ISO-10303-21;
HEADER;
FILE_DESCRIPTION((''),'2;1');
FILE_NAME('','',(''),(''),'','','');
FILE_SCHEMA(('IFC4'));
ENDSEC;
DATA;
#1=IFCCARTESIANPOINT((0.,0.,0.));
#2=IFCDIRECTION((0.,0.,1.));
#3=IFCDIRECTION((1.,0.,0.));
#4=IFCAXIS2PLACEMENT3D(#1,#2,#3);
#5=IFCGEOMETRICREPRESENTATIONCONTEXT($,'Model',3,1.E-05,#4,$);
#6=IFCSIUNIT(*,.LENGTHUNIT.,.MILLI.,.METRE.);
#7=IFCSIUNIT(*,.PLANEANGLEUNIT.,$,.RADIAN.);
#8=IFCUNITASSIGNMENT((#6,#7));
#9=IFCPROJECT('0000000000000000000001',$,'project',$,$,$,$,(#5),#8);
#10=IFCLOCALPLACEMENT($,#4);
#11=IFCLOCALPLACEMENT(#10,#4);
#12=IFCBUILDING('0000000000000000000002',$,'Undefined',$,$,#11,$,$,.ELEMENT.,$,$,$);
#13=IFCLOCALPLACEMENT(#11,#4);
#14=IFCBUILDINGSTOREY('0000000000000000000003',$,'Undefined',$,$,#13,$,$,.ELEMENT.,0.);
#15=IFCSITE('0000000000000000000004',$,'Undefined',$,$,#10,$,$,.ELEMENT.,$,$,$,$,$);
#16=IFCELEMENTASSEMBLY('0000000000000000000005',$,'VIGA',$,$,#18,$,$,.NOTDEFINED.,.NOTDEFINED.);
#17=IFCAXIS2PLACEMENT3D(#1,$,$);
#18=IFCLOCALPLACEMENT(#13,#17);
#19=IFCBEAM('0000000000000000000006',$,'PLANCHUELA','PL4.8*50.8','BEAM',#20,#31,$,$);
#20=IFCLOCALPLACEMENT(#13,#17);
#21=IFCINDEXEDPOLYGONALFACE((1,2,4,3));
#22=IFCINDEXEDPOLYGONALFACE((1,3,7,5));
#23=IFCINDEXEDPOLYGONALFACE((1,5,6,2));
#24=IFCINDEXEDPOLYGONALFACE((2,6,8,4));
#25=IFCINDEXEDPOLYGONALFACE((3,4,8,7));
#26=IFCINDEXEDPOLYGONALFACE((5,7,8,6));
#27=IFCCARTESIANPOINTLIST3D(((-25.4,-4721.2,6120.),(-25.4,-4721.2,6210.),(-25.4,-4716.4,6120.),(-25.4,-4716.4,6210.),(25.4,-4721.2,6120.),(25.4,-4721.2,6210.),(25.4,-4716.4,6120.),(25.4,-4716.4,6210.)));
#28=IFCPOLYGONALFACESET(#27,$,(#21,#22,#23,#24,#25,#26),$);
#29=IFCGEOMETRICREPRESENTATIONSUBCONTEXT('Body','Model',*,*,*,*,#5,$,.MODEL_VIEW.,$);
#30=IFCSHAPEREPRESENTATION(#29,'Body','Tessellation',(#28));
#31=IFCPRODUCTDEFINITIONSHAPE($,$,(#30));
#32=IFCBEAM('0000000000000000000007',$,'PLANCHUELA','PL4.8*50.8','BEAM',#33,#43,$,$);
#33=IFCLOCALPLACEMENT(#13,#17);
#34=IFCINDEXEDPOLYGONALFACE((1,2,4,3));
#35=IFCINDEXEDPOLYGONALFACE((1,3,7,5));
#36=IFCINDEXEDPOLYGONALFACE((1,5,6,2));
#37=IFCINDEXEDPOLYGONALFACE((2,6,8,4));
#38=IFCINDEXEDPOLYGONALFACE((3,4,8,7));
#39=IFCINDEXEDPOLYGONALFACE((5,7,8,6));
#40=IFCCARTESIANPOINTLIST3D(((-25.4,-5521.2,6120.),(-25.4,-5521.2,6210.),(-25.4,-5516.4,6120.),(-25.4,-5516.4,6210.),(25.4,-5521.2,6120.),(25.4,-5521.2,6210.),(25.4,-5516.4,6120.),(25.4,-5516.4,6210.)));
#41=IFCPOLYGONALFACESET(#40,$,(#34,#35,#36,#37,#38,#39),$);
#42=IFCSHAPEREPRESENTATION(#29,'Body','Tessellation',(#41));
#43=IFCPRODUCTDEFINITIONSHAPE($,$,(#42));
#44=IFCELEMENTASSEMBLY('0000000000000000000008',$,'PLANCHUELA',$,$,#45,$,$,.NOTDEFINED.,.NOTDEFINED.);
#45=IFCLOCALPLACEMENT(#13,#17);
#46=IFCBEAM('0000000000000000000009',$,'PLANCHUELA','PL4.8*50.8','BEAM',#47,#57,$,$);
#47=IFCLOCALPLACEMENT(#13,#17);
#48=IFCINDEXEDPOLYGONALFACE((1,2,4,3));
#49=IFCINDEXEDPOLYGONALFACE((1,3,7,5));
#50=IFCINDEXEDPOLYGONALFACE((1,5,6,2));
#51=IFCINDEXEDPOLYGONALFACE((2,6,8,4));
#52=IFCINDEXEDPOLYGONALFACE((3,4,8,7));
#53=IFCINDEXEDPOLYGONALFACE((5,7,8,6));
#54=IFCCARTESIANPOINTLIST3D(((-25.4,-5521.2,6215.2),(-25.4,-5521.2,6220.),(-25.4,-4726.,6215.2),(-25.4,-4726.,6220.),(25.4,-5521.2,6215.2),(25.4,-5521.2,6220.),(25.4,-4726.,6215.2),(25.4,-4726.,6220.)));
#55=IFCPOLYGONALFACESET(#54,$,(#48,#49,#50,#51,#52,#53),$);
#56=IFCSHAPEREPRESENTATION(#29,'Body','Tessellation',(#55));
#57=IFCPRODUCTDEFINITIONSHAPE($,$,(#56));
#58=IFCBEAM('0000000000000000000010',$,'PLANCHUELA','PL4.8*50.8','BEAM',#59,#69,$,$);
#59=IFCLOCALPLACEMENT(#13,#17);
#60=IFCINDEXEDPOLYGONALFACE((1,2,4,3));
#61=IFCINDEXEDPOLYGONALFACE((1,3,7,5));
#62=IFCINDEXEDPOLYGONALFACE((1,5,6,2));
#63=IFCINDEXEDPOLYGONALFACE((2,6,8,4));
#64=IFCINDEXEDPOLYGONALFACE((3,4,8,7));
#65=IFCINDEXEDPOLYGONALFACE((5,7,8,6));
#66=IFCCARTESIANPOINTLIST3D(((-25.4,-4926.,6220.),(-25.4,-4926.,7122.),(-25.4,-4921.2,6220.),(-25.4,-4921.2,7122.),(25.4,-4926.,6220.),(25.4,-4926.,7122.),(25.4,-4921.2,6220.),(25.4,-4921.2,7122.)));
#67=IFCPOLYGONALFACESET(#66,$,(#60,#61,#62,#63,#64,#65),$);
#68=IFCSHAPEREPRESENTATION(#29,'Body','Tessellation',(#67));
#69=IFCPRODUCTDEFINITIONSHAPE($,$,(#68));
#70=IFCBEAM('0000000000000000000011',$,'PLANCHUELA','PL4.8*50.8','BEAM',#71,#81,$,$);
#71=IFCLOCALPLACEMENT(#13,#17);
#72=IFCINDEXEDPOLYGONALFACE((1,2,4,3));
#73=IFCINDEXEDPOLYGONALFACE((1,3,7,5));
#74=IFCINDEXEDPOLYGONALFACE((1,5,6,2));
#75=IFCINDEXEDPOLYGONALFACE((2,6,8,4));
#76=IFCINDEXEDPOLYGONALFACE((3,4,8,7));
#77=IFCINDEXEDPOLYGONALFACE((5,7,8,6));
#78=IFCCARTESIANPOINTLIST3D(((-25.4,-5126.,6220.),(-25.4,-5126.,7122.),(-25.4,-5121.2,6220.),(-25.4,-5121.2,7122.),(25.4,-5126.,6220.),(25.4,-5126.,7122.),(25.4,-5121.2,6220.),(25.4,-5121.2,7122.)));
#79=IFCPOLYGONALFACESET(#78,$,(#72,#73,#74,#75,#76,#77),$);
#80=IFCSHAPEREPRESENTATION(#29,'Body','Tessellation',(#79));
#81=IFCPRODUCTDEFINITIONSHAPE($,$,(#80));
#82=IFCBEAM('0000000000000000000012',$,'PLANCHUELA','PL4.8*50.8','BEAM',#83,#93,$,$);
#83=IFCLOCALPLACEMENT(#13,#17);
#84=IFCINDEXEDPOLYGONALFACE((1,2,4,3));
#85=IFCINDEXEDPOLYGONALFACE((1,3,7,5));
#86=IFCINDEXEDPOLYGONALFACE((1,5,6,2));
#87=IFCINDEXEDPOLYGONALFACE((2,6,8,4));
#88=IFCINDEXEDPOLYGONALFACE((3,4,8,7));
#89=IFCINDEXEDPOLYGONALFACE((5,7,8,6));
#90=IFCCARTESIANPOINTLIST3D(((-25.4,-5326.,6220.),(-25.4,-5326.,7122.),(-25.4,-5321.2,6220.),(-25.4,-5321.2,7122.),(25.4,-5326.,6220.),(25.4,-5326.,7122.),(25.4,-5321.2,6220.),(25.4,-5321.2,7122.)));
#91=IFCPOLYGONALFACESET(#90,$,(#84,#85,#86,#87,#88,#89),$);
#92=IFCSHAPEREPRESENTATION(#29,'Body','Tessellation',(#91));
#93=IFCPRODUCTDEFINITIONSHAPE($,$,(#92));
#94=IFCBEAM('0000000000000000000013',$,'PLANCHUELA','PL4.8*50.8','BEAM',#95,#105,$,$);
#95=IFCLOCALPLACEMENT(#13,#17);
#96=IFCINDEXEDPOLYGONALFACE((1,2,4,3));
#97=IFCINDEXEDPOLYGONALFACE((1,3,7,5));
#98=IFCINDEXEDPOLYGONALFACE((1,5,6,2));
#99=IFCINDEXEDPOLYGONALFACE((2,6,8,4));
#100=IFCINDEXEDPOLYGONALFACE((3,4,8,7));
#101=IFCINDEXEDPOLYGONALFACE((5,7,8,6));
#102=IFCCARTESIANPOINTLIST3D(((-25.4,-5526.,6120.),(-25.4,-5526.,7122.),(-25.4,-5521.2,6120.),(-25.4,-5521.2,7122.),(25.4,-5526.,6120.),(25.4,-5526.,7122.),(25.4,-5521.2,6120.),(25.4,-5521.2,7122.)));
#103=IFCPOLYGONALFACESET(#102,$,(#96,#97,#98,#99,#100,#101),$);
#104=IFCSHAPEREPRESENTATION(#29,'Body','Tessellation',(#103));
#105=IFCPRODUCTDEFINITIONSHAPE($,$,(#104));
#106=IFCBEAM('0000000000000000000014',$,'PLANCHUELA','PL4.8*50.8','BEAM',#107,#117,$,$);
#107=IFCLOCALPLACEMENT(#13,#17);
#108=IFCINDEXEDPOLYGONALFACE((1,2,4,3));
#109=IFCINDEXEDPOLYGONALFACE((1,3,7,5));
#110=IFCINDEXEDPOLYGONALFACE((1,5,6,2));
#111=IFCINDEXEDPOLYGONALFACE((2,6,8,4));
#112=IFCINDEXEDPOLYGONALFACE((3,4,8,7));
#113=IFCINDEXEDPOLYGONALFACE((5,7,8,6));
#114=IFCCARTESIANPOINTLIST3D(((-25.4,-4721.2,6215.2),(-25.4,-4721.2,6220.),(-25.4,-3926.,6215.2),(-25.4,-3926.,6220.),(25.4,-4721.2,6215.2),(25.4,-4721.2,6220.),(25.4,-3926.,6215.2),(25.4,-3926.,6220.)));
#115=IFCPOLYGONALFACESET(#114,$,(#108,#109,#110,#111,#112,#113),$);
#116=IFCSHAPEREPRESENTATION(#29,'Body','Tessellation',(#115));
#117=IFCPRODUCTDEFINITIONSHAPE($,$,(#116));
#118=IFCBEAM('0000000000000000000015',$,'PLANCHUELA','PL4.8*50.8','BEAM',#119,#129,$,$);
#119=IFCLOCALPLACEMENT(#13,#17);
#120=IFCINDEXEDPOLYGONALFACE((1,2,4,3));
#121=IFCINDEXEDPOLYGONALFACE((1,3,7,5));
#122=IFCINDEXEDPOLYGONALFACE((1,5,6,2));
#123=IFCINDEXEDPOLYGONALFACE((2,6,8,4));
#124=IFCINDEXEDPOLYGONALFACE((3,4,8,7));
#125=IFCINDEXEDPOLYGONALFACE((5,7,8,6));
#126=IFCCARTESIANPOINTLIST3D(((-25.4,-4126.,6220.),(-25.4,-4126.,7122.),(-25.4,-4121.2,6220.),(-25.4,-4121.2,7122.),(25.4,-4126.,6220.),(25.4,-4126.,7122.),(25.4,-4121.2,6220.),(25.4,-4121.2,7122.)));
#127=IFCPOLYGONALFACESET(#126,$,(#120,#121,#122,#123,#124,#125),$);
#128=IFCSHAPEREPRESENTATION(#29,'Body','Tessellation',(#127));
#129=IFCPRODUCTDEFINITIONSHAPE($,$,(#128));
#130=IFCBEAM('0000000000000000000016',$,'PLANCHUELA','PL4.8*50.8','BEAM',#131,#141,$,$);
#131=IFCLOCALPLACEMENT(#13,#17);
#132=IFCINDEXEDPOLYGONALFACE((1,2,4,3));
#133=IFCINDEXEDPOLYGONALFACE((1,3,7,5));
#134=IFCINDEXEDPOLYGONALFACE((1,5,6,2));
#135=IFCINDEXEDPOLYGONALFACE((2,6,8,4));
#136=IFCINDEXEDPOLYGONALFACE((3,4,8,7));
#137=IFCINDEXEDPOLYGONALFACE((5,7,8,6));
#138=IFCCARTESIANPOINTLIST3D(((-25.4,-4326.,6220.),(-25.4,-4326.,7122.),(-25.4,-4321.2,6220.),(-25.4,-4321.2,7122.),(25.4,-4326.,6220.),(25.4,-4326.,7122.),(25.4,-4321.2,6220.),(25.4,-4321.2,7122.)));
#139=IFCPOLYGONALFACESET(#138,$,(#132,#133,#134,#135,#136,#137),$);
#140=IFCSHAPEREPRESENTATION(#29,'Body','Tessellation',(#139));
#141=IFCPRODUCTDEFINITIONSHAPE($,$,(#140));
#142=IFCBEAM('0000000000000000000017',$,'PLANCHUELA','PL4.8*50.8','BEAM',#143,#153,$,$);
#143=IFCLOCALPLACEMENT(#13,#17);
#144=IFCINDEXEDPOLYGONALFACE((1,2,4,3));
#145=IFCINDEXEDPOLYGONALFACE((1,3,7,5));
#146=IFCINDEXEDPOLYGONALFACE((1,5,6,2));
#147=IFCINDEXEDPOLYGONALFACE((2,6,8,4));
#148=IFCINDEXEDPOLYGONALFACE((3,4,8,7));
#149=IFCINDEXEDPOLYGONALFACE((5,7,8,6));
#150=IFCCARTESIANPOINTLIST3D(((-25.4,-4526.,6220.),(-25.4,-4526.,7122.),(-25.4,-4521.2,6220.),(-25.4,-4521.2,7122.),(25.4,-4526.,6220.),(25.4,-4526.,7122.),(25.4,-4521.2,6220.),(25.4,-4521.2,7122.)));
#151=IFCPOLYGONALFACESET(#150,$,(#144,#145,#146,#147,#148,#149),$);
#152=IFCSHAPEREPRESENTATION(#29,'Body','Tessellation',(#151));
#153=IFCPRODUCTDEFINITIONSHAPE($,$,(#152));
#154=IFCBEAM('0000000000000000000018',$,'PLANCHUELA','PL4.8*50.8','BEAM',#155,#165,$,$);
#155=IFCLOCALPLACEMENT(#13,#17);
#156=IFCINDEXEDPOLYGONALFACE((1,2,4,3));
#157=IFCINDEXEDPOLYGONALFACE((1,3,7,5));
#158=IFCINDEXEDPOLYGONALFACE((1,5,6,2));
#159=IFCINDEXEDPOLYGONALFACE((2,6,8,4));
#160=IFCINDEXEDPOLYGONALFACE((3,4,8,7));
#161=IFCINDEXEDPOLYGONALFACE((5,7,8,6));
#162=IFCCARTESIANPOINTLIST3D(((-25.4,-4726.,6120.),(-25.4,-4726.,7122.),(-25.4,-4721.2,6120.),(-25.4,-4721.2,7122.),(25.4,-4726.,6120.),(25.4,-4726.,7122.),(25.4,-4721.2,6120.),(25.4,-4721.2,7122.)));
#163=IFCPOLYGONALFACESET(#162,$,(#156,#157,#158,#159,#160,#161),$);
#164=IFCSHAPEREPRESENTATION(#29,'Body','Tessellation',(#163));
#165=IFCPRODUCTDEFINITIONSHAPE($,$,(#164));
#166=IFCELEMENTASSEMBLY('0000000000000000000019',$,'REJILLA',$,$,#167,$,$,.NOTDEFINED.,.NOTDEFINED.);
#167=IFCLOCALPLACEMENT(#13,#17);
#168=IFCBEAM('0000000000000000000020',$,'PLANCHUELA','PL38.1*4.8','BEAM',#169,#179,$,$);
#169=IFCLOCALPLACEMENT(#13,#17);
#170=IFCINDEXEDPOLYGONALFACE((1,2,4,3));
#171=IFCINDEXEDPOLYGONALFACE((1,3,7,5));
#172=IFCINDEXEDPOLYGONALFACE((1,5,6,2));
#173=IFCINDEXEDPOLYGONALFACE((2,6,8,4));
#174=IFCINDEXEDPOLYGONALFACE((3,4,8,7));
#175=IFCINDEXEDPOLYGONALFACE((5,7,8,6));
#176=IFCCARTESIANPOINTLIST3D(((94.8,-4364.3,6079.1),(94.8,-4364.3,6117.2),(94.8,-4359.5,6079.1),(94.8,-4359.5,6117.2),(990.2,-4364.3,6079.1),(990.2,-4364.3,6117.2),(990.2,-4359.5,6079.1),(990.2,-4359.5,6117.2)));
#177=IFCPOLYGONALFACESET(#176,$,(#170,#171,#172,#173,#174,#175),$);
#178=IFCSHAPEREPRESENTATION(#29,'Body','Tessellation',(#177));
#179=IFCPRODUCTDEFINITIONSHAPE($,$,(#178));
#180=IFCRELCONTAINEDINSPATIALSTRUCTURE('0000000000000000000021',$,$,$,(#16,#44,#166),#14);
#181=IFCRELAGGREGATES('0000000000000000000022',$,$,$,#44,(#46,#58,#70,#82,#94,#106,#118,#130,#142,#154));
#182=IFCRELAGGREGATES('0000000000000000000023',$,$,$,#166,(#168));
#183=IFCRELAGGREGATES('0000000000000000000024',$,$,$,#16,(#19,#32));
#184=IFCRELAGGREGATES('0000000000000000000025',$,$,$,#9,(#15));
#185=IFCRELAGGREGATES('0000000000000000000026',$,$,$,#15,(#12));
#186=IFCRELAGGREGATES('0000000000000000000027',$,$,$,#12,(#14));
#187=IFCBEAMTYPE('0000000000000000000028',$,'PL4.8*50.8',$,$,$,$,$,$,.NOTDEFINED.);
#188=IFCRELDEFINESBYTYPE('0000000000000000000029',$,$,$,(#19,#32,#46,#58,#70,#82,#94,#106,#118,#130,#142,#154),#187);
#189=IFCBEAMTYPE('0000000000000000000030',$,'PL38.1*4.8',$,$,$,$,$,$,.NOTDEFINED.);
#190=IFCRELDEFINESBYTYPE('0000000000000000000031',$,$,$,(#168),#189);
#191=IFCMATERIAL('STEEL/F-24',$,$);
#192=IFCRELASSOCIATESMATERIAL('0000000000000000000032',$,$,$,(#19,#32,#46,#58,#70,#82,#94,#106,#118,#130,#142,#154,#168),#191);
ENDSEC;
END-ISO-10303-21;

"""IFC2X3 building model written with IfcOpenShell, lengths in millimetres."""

from ifc_helpers import new_model, si_unit, frame, origin_with_axes, origin_2d_with_axis, place, context, subcontext, project, spatial, rectangle, extrude, material, type_object, element, aggregate, save


model = new_model("IFC2X3")

# Units and contexts
model_context = context("Model", 3, precision=1e-05, world=origin_with_axes())
body_context = subcontext(model_context, "Body", "Model", "MODEL_VIEW")
ifc_project = project(units=[si_unit("LENGTHUNIT", "METRE", prefix="MILLI"), si_unit("PLANEANGLEUNIT", "RADIAN")], contexts=[model_context])

# Site, building, storey
site_placement = place(None, origin_with_axes())
site = spatial("IfcSite", under=ifc_project, at=site_placement, Name="Undefined", CompositionType="ELEMENT")
building_placement = place(site_placement, origin_with_axes())
building = spatial("IfcBuilding", under=site, at=building_placement, Name="Undefined", CompositionType="ELEMENT")
storey_placement = place(building_placement, origin_with_axes())
storey = spatial("IfcBuildingStorey", under=building, at=storey_placement, Name="Undefined", CompositionType="ELEMENT", Elevation=0.0)

# Element assemblies, beams
assembly_1_placement = place(storey_placement, origin_with_axes())
assembly_1 = element("IfcElementAssembly", 1, at=assembly_1_placement, inside=storey, Name="VIGA", AssemblyPlace="NOTDEFINED", PredefinedType="NOTDEFINED")
ifc_material_1 = material(Name="STEEL/F-24")
beam_type_1 = type_object("IfcBeamType", Name="PL4.8*50.8", PredefinedType="NOTDEFINED")
beam_1_placement = place(assembly_1_placement, frame((0.0, -4718.8, 6210.0), z_axis=(-1.0, 0.0, 0.0), x_axis=(0.0, 0.0, -1.0)))
beam_1 = element("IfcBeam", 2, at=beam_1_placement, type_object=beam_type_1, material=ifc_material_1, Name="PLANCHUELA", Description="PL4.8*50.8", ObjectType="BEAM", context=body_context, shape_type="SweptSolid", body=[
    extrude(rectangle(XDim=4.8, YDim=50.8, at=origin_2d_with_axis()), frame((90.0, 0.0, 0.0), z_axis=(-1.0, 0.0, 0.0), x_axis=(0.0, -1.0, 0.0)), (0.0, 0.0, 1.0), 90.0),
])
beam_2_placement = place(assembly_1_placement, frame((0.0, -5518.8, 6210.0), z_axis=(-1.0, 0.0, 0.0), x_axis=(0.0, 0.0, -1.0)))
beam_2 = element("IfcBeam", 3, at=beam_2_placement, type_object=beam_type_1, material=ifc_material_1, Name="PLANCHUELA", Description="PL4.8*50.8", ObjectType="BEAM", context=body_context, shape_type="SweptSolid", body=[
    extrude(rectangle(XDim=4.8, YDim=50.8, at=origin_2d_with_axis()), frame((90.0, 0.0, 0.0), z_axis=(-1.0, 0.0, 0.0), x_axis=(0.0, -1.0, 0.0)), (0.0, 0.0, 1.0), 90.0),
])
assembly_2_placement = place(storey_placement, origin_with_axes())
assembly_2 = element("IfcElementAssembly", 4, at=assembly_2_placement, inside=storey, Name="PLANCHUELA", AssemblyPlace="NOTDEFINED", PredefinedType="NOTDEFINED")
beam_3_placement = place(assembly_2_placement, frame((0.0, -5521.2, 6217.6), z_axis=(1.0, 0.0, 0.0), x_axis=(0.0, 1.0, 0.0)))
beam_3 = element("IfcBeam", 5, at=beam_3_placement, type_object=beam_type_1, material=ifc_material_1, Name="PLANCHUELA", Description="PL4.8*50.8", ObjectType="BEAM", context=body_context, shape_type="SweptSolid", body=[
    extrude(rectangle(XDim=4.8, YDim=50.8, at=origin_2d_with_axis()), frame((795.2, 0.0, 0.0), z_axis=(-1.0, 0.0, 0.0), x_axis=(0.0, -1.0, 0.0)), (0.0, 0.0, 1.0), 795.2),
])
beam_4_placement = place(assembly_2_placement, frame((0.0, -4923.6, 7122.0), z_axis=(1.0, 0.0, 0.0), x_axis=(0.0, 0.0, -1.0)))
beam_4 = element("IfcBeam", 6, at=beam_4_placement, type_object=beam_type_1, material=ifc_material_1, Name="PLANCHUELA", Description="PL4.8*50.8", ObjectType="BEAM", context=body_context, shape_type="SweptSolid", body=[
    extrude(rectangle(XDim=4.8, YDim=50.8, at=origin_2d_with_axis()), frame((902.0, 0.0, 0.0), z_axis=(-1.0, 0.0, 0.0), x_axis=(0.0, -1.0, 0.0)), (0.0, 0.0, 1.0), 902.0),
])
beam_5_placement = place(assembly_2_placement, frame((0.0, -5123.6, 7122.0), z_axis=(1.0, 0.0, 0.0), x_axis=(0.0, 0.0, -1.0)))
beam_5 = element("IfcBeam", 7, at=beam_5_placement, type_object=beam_type_1, material=ifc_material_1, Name="PLANCHUELA", Description="PL4.8*50.8", ObjectType="BEAM", context=body_context, shape_type="SweptSolid", body=[
    extrude(rectangle(XDim=4.8, YDim=50.8, at=origin_2d_with_axis()), frame((902.0, 0.0, 0.0), z_axis=(-1.0, 0.0, 0.0), x_axis=(0.0, -1.0, 0.0)), (0.0, 0.0, 1.0), 902.0),
])
beam_6_placement = place(assembly_2_placement, frame((0.0, -5323.6, 7122.0), z_axis=(1.0, 0.0, 0.0), x_axis=(0.0, 0.0, -1.0)))
beam_6 = element("IfcBeam", 8, at=beam_6_placement, type_object=beam_type_1, material=ifc_material_1, Name="PLANCHUELA", Description="PL4.8*50.8", ObjectType="BEAM", context=body_context, shape_type="SweptSolid", body=[
    extrude(rectangle(XDim=4.8, YDim=50.8, at=origin_2d_with_axis()), frame((902.0, 0.0, 0.0), z_axis=(-1.0, 0.0, 0.0), x_axis=(0.0, -1.0, 0.0)), (0.0, 0.0, 1.0), 902.0),
])
beam_7_placement = place(assembly_2_placement, frame((0.0, -5523.6, 7122.0), z_axis=(1.0, 0.0, 0.0), x_axis=(0.0, 0.0, -1.0)))
beam_7 = element("IfcBeam", 9, at=beam_7_placement, type_object=beam_type_1, material=ifc_material_1, Name="PLANCHUELA", Description="PL4.8*50.8", ObjectType="BEAM", context=body_context, shape_type="SweptSolid", body=[
    extrude(rectangle(XDim=4.8, YDim=50.8, at=origin_2d_with_axis()), frame((1002.0, 0.0, 0.0), z_axis=(-1.0, 0.0, 0.0), x_axis=(0.0, -1.0, 0.0)), (0.0, 0.0, 1.0), 1002.0),
])
beam_8_placement = place(assembly_2_placement, frame((0.0, -4721.2, 6217.6), z_axis=(1.0, 0.0, 0.0), x_axis=(0.0, 1.0, 0.0)))
beam_8 = element("IfcBeam", 10, at=beam_8_placement, type_object=beam_type_1, material=ifc_material_1, Name="PLANCHUELA", Description="PL4.8*50.8", ObjectType="BEAM", context=body_context, shape_type="SweptSolid", body=[
    extrude(rectangle(XDim=4.8, YDim=50.8, at=origin_2d_with_axis()), frame((795.2, 0.0, 0.0), z_axis=(-1.0, 0.0, 0.0), x_axis=(0.0, -1.0, 0.0)), (0.0, 0.0, 1.0), 795.2),
])
beam_9_placement = place(assembly_2_placement, frame((0.0, -4123.6, 7122.0), z_axis=(1.0, 0.0, 0.0), x_axis=(0.0, 0.0, -1.0)))
beam_9 = element("IfcBeam", 11, at=beam_9_placement, type_object=beam_type_1, material=ifc_material_1, Name="PLANCHUELA", Description="PL4.8*50.8", ObjectType="BEAM", context=body_context, shape_type="SweptSolid", body=[
    extrude(rectangle(XDim=4.8, YDim=50.8, at=origin_2d_with_axis()), frame((902.0, 0.0, 0.0), z_axis=(-1.0, 0.0, 0.0), x_axis=(0.0, -1.0, 0.0)), (0.0, 0.0, 1.0), 902.0),
])
beam_10_placement = place(assembly_2_placement, frame((0.0, -4323.6, 7122.0), z_axis=(1.0, 0.0, 0.0), x_axis=(0.0, 0.0, -1.0)))
beam_10 = element("IfcBeam", 12, at=beam_10_placement, type_object=beam_type_1, material=ifc_material_1, Name="PLANCHUELA", Description="PL4.8*50.8", ObjectType="BEAM", context=body_context, shape_type="SweptSolid", body=[
    extrude(rectangle(XDim=4.8, YDim=50.8, at=origin_2d_with_axis()), frame((902.0, 0.0, 0.0), z_axis=(-1.0, 0.0, 0.0), x_axis=(0.0, -1.0, 0.0)), (0.0, 0.0, 1.0), 902.0),
])
beam_11_placement = place(assembly_2_placement, frame((0.0, -4523.6, 7122.0), z_axis=(1.0, 0.0, 0.0), x_axis=(0.0, 0.0, -1.0)))
beam_11 = element("IfcBeam", 13, at=beam_11_placement, type_object=beam_type_1, material=ifc_material_1, Name="PLANCHUELA", Description="PL4.8*50.8", ObjectType="BEAM", context=body_context, shape_type="SweptSolid", body=[
    extrude(rectangle(XDim=4.8, YDim=50.8, at=origin_2d_with_axis()), frame((902.0, 0.0, 0.0), z_axis=(-1.0, 0.0, 0.0), x_axis=(0.0, -1.0, 0.0)), (0.0, 0.0, 1.0), 902.0),
])
beam_12_placement = place(assembly_2_placement, frame((0.0, -4723.6, 7122.0), z_axis=(1.0, 0.0, 0.0), x_axis=(0.0, 0.0, -1.0)))
beam_12 = element("IfcBeam", 14, at=beam_12_placement, type_object=beam_type_1, material=ifc_material_1, Name="PLANCHUELA", Description="PL4.8*50.8", ObjectType="BEAM", context=body_context, shape_type="SweptSolid", body=[
    extrude(rectangle(XDim=4.8, YDim=50.8, at=origin_2d_with_axis()), frame((1002.0, 0.0, 0.0), z_axis=(-1.0, 0.0, 0.0), x_axis=(0.0, -1.0, 0.0)), (0.0, 0.0, 1.0), 1002.0),
])
aggregate(assembly_2, [beam_3, beam_4, beam_5, beam_6, beam_7, beam_8, beam_9, beam_10, beam_11, beam_12])

# Element assembly, beam
assembly_3_placement = place(storey_placement, origin_with_axes())
assembly_3 = element("IfcElementAssembly", 15, at=assembly_3_placement, inside=storey, Name="REJILLA", AssemblyPlace="NOTDEFINED", PredefinedType="NOTDEFINED")
beam_type_2 = type_object("IfcBeamType", Name="PL38.1*4.8", PredefinedType="NOTDEFINED")
beam_13_placement = place(assembly_3_placement, frame((990.2, -4361.9, 6098.2), z_axis=(-0.000045, 0.0, -1.0), x_axis=(-1.0, 0.0, 0.000045)))
beam_13 = element("IfcBeam", 16, at=beam_13_placement, type_object=beam_type_2, material=ifc_material_1, Name="PLANCHUELA", Description="PL38.1*4.8", ObjectType="BEAM", context=body_context, shape_type="SweptSolid", body=[
    extrude(rectangle(XDim=4.8, YDim=38.1, at=origin_2d_with_axis()), frame((895.4, 0.0, 0.0), z_axis=(-1.0, 0.0, 0.0), x_axis=(0.0, -1.0, 0.0)), (0.0, 0.0, 1.0), 895.4),
])

aggregate(assembly_3, [beam_13])

aggregate(assembly_1, [beam_1, beam_2])

save(model, "model.ifc")
